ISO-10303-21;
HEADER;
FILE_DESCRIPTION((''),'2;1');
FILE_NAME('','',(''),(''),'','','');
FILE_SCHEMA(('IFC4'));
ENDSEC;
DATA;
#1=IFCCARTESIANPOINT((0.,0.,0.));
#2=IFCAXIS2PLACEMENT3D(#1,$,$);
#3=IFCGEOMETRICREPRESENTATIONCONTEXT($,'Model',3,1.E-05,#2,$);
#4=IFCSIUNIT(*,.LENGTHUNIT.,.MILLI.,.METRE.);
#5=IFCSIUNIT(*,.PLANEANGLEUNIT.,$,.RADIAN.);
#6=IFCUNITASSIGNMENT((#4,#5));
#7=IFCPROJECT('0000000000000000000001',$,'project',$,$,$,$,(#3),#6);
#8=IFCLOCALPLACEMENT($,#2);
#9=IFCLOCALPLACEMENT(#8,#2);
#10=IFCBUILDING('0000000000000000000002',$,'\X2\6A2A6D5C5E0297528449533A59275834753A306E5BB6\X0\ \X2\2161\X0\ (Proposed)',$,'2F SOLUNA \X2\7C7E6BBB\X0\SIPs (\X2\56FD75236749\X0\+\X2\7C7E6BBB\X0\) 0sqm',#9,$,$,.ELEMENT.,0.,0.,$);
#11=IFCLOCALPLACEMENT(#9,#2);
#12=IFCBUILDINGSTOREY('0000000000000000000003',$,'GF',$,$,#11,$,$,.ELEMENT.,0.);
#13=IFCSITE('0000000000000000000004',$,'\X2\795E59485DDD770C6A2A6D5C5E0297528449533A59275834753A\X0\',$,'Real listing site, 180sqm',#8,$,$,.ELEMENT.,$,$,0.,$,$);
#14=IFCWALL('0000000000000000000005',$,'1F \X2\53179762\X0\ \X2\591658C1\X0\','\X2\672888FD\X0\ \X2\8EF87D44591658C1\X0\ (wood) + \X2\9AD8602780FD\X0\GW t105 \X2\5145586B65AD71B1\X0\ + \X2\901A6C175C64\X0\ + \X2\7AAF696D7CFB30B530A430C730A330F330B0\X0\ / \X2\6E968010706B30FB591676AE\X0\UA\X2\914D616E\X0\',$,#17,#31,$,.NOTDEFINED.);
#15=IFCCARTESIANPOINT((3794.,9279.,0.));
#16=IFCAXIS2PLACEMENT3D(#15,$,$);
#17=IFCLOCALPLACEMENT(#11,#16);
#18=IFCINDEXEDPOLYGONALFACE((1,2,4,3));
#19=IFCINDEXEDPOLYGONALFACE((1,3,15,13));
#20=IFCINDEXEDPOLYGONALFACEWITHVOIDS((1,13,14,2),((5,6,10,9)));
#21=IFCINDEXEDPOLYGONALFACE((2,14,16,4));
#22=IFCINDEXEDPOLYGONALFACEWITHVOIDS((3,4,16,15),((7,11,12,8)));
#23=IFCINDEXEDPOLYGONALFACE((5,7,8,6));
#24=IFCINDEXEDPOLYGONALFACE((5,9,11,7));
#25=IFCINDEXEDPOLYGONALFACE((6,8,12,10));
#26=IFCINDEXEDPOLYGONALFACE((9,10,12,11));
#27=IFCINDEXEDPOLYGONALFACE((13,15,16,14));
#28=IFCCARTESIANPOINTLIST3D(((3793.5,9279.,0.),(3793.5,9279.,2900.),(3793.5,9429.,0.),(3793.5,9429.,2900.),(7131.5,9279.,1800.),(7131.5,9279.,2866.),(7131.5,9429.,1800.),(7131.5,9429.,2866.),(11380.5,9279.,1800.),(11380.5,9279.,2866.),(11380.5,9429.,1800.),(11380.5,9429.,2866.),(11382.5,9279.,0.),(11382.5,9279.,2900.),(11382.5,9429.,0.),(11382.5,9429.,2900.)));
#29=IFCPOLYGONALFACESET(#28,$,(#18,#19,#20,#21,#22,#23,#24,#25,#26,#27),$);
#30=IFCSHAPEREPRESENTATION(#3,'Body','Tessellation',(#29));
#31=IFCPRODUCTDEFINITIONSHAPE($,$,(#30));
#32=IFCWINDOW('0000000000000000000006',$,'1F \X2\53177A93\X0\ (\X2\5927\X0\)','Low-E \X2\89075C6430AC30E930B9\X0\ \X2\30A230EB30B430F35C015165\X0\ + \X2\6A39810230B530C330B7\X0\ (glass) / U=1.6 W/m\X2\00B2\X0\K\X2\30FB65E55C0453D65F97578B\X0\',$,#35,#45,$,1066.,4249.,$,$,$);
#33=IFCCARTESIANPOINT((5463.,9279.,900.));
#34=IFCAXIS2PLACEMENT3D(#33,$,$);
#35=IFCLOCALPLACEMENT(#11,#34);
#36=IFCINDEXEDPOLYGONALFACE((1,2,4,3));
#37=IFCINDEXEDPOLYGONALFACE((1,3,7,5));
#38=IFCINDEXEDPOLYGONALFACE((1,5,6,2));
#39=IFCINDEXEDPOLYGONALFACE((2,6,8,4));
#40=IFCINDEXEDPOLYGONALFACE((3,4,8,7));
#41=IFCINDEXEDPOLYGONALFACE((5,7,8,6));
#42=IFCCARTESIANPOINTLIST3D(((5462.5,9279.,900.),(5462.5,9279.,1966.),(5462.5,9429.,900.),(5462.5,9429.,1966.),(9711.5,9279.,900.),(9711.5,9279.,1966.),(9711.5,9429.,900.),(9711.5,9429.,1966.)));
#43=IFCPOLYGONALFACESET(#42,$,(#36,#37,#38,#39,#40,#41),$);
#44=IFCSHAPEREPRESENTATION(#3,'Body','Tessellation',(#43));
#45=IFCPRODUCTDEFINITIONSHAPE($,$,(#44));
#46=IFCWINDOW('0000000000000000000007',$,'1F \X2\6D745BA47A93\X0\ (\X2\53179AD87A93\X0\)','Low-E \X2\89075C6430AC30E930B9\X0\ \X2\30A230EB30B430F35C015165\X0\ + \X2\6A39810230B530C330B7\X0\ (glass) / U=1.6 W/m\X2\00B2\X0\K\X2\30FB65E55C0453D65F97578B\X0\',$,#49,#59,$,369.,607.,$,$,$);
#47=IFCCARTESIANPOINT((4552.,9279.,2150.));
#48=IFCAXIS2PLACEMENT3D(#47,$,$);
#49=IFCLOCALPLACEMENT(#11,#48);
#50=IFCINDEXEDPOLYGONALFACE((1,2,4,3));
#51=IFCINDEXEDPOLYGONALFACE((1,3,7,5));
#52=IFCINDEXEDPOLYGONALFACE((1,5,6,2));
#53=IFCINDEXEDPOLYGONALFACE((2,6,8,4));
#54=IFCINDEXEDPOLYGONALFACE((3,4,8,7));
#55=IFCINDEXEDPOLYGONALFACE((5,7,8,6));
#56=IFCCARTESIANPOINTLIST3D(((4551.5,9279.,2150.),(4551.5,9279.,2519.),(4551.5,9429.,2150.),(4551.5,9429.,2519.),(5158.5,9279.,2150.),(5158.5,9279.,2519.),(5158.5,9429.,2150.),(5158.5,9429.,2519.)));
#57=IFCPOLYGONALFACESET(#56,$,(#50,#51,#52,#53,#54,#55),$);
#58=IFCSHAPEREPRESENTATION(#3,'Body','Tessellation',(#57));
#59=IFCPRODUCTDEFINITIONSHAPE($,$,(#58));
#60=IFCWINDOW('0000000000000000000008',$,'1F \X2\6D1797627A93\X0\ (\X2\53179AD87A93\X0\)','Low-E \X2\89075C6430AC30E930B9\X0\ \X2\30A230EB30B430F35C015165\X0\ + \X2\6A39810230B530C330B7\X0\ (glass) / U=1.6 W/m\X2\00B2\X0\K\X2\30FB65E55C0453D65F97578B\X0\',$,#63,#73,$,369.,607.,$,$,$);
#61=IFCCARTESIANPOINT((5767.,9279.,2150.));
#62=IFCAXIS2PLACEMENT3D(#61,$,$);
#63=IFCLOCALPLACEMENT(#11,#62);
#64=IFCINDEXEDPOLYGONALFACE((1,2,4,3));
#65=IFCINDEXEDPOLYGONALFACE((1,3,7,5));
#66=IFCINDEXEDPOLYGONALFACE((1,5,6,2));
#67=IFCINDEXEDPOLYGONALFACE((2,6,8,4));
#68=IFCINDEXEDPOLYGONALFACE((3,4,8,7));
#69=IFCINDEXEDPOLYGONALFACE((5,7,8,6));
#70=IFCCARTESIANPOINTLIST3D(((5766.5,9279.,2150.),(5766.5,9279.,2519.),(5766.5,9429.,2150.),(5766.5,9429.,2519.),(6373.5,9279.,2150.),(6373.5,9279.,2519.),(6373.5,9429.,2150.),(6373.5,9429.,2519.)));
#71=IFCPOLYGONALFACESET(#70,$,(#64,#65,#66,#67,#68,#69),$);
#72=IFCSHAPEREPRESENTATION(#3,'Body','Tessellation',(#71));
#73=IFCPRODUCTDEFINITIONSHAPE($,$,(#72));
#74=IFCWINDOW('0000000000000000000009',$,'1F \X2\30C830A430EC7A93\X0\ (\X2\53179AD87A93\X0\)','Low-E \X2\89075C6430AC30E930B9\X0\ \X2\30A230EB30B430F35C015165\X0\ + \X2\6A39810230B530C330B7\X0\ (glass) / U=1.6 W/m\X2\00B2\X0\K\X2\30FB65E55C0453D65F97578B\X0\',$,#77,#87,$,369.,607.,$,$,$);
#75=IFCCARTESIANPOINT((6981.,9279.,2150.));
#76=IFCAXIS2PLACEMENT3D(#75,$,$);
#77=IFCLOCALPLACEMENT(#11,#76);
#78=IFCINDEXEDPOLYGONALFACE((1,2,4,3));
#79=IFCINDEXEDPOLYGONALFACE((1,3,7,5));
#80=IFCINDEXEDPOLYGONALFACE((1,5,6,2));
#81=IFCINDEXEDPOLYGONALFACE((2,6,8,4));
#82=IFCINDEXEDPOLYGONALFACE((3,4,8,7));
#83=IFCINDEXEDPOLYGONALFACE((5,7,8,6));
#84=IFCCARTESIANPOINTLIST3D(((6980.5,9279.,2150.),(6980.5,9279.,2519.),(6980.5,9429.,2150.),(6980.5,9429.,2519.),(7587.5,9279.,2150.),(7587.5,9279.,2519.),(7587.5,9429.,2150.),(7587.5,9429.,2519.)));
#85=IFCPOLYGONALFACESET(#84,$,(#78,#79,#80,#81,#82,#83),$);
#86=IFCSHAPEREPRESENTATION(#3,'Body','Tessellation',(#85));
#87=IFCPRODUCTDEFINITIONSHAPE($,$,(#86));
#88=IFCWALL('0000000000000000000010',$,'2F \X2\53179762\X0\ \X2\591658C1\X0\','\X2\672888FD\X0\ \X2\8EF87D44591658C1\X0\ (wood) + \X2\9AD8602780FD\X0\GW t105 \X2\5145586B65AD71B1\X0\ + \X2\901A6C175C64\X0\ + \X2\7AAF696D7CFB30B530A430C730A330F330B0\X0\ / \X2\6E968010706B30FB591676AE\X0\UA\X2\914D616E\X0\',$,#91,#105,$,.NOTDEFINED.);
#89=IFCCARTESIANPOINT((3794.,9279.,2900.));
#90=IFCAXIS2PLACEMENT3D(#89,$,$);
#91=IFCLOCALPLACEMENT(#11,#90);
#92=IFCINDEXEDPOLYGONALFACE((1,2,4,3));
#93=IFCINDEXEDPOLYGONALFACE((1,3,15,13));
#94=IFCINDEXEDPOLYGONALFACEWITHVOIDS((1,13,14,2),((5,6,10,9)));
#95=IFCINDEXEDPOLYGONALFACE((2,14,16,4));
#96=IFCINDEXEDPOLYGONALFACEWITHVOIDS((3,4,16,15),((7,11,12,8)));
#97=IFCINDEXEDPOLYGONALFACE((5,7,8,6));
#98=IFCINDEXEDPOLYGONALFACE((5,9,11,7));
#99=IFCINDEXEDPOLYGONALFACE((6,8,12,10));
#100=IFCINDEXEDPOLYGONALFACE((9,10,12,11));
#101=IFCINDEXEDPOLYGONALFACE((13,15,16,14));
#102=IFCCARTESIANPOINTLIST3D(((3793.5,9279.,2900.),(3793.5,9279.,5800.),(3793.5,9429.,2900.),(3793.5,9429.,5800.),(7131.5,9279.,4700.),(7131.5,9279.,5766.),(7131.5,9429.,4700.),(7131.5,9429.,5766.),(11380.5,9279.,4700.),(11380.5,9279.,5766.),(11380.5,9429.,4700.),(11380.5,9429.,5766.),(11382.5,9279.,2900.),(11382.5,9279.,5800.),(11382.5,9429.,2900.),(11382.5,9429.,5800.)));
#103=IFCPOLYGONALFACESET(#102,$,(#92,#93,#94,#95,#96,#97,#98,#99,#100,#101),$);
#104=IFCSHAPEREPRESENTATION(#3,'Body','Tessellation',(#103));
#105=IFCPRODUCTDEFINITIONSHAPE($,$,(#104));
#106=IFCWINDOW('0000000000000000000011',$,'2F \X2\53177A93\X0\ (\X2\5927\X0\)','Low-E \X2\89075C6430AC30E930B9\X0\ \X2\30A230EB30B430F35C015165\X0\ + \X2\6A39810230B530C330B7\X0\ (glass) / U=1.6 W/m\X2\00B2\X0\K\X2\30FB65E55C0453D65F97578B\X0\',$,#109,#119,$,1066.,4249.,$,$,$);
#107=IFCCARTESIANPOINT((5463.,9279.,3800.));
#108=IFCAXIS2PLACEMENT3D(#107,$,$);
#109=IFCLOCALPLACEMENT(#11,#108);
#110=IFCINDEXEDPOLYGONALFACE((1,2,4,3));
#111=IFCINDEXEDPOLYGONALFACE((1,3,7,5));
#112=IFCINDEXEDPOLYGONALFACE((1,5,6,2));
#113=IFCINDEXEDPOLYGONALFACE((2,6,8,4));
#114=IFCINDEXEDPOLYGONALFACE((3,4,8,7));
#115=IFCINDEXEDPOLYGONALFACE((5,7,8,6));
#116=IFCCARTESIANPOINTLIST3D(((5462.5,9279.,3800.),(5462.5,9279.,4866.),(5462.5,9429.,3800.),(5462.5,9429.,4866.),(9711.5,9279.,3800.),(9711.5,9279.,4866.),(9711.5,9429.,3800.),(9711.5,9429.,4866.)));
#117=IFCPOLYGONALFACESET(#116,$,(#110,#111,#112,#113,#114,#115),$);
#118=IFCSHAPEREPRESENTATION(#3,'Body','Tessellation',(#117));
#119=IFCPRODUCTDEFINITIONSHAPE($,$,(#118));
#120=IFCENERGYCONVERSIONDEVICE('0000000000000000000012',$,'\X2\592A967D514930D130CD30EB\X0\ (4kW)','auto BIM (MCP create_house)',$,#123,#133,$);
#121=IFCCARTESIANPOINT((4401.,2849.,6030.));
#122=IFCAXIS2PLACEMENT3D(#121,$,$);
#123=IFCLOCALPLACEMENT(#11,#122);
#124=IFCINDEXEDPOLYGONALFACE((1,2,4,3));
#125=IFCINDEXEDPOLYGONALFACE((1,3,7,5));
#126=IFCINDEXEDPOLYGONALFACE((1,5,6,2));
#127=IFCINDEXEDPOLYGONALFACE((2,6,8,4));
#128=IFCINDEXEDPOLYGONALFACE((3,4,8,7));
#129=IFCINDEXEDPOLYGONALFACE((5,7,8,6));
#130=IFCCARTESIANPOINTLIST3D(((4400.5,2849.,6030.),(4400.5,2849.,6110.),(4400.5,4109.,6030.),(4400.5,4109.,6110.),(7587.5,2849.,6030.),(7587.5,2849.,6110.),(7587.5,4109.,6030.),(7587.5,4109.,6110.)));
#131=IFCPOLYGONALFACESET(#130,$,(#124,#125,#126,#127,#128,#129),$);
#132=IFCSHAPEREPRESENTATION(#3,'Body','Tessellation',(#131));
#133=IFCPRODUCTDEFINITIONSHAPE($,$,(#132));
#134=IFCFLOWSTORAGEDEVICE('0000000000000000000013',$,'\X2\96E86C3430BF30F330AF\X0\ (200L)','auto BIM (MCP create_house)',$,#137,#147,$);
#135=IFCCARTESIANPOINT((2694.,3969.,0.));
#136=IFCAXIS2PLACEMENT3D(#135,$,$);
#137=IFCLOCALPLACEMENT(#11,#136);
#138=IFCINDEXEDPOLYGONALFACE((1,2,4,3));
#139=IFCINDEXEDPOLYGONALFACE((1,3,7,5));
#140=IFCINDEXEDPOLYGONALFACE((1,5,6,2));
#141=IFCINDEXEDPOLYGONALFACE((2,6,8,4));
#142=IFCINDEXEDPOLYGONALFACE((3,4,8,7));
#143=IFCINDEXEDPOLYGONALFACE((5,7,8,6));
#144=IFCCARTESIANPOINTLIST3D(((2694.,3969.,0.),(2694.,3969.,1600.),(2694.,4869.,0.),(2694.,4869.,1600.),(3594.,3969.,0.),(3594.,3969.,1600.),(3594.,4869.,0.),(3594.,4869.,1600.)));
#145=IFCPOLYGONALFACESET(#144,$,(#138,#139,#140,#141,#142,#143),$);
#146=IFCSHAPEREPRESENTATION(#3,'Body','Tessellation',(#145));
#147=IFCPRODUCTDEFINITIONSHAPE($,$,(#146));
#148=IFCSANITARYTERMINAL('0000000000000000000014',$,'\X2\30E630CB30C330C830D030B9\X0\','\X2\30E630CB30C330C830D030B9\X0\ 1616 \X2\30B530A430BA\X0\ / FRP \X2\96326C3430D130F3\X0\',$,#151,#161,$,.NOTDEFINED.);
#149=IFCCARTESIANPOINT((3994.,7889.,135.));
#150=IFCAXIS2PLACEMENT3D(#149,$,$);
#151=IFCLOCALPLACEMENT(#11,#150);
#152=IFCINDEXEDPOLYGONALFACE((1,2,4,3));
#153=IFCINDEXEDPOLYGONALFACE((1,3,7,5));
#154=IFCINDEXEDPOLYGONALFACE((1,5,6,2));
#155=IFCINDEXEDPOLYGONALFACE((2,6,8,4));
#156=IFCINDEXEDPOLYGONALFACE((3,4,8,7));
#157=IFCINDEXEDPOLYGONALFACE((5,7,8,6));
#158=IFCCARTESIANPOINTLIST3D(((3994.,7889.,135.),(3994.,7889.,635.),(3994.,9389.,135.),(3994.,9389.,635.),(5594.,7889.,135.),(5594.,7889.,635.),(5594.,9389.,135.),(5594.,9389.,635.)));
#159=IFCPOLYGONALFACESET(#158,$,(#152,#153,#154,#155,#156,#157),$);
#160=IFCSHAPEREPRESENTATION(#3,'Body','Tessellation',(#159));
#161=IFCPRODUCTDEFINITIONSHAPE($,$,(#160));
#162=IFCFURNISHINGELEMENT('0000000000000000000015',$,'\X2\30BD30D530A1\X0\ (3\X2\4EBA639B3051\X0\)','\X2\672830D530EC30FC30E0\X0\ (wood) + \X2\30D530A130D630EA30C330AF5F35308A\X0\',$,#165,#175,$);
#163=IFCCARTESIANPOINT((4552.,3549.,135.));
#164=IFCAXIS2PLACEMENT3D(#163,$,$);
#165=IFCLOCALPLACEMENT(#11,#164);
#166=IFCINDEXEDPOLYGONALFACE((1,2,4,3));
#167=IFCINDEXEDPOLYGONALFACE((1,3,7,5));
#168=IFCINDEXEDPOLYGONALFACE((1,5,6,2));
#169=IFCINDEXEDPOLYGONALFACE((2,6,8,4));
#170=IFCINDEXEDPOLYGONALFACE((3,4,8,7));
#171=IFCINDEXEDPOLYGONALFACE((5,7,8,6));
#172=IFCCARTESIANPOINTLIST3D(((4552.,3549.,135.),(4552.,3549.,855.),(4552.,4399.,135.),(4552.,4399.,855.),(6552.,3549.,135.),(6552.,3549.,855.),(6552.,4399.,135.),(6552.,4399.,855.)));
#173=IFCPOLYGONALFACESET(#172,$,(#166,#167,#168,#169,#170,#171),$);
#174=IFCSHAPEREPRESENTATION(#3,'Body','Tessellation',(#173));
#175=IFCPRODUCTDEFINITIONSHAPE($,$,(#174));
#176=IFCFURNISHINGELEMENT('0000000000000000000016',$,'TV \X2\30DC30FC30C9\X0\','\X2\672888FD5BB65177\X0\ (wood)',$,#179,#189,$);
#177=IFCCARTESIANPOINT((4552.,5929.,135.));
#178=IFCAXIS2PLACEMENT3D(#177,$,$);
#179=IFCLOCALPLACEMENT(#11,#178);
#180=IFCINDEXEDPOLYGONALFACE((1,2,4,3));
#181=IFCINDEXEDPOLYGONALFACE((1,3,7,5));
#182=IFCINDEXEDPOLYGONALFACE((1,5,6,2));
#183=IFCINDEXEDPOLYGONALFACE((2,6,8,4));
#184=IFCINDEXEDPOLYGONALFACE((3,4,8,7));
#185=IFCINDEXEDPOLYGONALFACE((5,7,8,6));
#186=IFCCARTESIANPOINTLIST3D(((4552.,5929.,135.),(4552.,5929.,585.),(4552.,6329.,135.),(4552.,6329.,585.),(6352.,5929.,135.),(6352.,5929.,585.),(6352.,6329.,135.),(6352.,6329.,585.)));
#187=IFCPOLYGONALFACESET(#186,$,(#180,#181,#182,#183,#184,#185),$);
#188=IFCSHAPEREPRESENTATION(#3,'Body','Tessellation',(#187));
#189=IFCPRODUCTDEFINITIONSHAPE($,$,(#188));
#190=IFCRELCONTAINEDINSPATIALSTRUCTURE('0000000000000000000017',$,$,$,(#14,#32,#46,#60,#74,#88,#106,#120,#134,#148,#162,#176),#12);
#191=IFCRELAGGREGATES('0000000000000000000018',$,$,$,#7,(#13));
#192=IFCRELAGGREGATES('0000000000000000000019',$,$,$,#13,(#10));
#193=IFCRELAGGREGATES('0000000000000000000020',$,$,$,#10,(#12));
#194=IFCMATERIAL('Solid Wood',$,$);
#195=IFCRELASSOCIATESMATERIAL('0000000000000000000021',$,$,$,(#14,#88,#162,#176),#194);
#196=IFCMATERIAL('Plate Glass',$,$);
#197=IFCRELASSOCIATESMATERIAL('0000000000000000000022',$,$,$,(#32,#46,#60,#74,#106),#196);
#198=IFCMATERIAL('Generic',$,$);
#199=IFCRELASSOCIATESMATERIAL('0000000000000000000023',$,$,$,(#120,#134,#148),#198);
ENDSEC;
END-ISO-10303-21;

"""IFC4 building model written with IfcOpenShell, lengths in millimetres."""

from ifc_helpers import new_model, si_unit, frame, frame_2d, origin, place, context, project, spatial, rectangle, extrude, material, element, fill, save


model = new_model("IFC4")

# Units and contexts
model_context = context("Model", 3, precision=1e-05, world=origin())
ifc_project = project(units=[si_unit("LENGTHUNIT", "METRE", prefix="MILLI"), si_unit("PLANEANGLEUNIT", "RADIAN")], contexts=[model_context])

# Site, building, storey
site_placement = place(None, origin())
site = spatial("IfcSite", under=ifc_project, at=site_placement, Name="神奈川県横浜市青葉区大場町", ObjectType="Real listing site, 180sqm", CompositionType="ELEMENT", RefElevation=0.0)
building_placement = place(site_placement, origin())
building = spatial("IfcBuilding", under=site, at=building_placement, Name="横浜市青葉区大場町の家 Ⅱ (Proposed)", ObjectType="2F SOLUNA 籾殻SIPs (国産杉+籾殻) 0sqm", CompositionType="ELEMENT", ElevationOfRefHeight=0.0, ElevationOfTerrain=0.0)
storey_placement = place(building_placement, origin())
storey = spatial("IfcBuildingStorey", under=building, at=storey_placement, Name="GF", CompositionType="ELEMENT", Elevation=0.0)

# Wall, openings, windows
ifc_material_1 = material(Name="Solid Wood")
wall_1_placement = place(storey_placement, frame((3794.0, 9279.0, 0.0)))
wall_1 = element("IfcWall", 1, at=wall_1_placement, inside=storey, material=ifc_material_1, Name="1F 北面 外壁", Description="木製 軸組外壁 (wood) + 高性能GW t105 充填断熱 + 通気層 + 窯業系サイディング / 準耐火・外皮UA配慮", PredefinedType="NOTDEFINED", context=model_context, shape_type="SweptSolid", body=[
    extrude(rectangle(XDim=7589.0, YDim=150.0, at=frame_2d((3794.0, 75.0))), frame((3794.0, 9279.0, 0.0)), (0.0, 0.0, 1.0), 2900.0),
])
opening_1_placement = place(storey_placement, frame((5463.0, 9279.0, 900.0)))
opening_1 = element("IfcOpeningElement", 2, at=opening_1_placement, cuts=wall_1, PredefinedType="NOTDEFINED", context=model_context, shape_type="SweptSolid", body=[
    extrude(rectangle(XDim=4249.0, YDim=150.0, at=frame_2d((2124.0, 75.0))), frame((5463.0, 9279.0, 900.0)), (0.0, 0.0, 1.0), 1066.0),
])
opening_2_placement = place(storey_placement, frame((4552.0, 9279.0, 2150.0)))
opening_2 = element("IfcOpeningElement", 3, at=opening_2_placement, cuts=wall_1, PredefinedType="NOTDEFINED", context=model_context, shape_type="SweptSolid", body=[
    extrude(rectangle(XDim=607.0, YDim=150.0, at=frame_2d((303.0, 75.0))), frame((4552.0, 9279.0, 2150.0)), (0.0, 0.0, 1.0), 369.0),
])
opening_3_placement = place(storey_placement, frame((5767.0, 9279.0, 2150.0)))
opening_3 = element("IfcOpeningElement", 4, at=opening_3_placement, cuts=wall_1, PredefinedType="NOTDEFINED", context=model_context, shape_type="SweptSolid", body=[
    extrude(rectangle(XDim=607.0, YDim=150.0, at=frame_2d((303.0, 75.0))), frame((5767.0, 9279.0, 2150.0)), (0.0, 0.0, 1.0), 369.0),
])
opening_4_placement = place(storey_placement, frame((6981.0, 9279.0, 2150.0)))
opening_4 = element("IfcOpeningElement", 5, at=opening_4_placement, cuts=wall_1, PredefinedType="NOTDEFINED", context=model_context, shape_type="SweptSolid", body=[
    extrude(rectangle(XDim=607.0, YDim=150.0, at=frame_2d((303.0, 75.0))), frame((6981.0, 9279.0, 2150.0)), (0.0, 0.0, 1.0), 369.0),
])
ifc_material_2 = material(Name="Plate Glass")
window_1_placement = place(storey_placement, frame((5463.0, 9279.0, 900.0)))
window_1 = element("IfcWindow", 6, at=window_1_placement, inside=storey, material=ifc_material_2, Name="1F 北窓 (大)", Description="Low-E 複層ガラス アルゴン封入 + 樹脂サッシ (glass) / U=1.6 W/m²K・日射取得型", OverallHeight=1066.0, OverallWidth=4249.0, context=model_context, shape_type="SweptSolid", body=[
    extrude(rectangle(XDim=4249.0, YDim=150.0, at=frame_2d((2124.0, 75.0))), frame((5463.0, 9279.0, 900.0)), (0.0, 0.0, 1.0), 1066.0),
])
fill(opening_1, window_1)
window_2_placement = place(storey_placement, frame((4552.0, 9279.0, 2150.0)))
window_2 = element("IfcWindow", 7, at=window_2_placement, inside=storey, material=ifc_material_2, Name="1F 浴室窓 (北高窓)", Description="Low-E 複層ガラス アルゴン封入 + 樹脂サッシ (glass) / U=1.6 W/m²K・日射取得型", OverallHeight=369.0, OverallWidth=607.0, context=model_context, shape_type="SweptSolid", body=[
    extrude(rectangle(XDim=607.0, YDim=150.0, at=frame_2d((303.0, 75.0))), frame((4552.0, 9279.0, 2150.0)), (0.0, 0.0, 1.0), 369.0),
])
fill(opening_2, window_2)
window_3_placement = place(storey_placement, frame((5767.0, 9279.0, 2150.0)))
window_3 = element("IfcWindow", 8, at=window_3_placement, inside=storey, material=ifc_material_2, Name="1F 洗面窓 (北高窓)", Description="Low-E 複層ガラス アルゴン封入 + 樹脂サッシ (glass) / U=1.6 W/m²K・日射取得型", OverallHeight=369.0, OverallWidth=607.0, context=model_context, shape_type="SweptSolid", body=[
    extrude(rectangle(XDim=607.0, YDim=150.0, at=frame_2d((303.0, 75.0))), frame((5767.0, 9279.0, 2150.0)), (0.0, 0.0, 1.0), 369.0),
])
fill(opening_3, window_3)
window_4_placement = place(storey_placement, frame((6981.0, 9279.0, 2150.0)))
window_4 = element("IfcWindow", 9, at=window_4_placement, inside=storey, material=ifc_material_2, Name="1F トイレ窓 (北高窓)", Description="Low-E 複層ガラス アルゴン封入 + 樹脂サッシ (glass) / U=1.6 W/m²K・日射取得型", OverallHeight=369.0, OverallWidth=607.0, context=model_context, shape_type="SweptSolid", body=[
    extrude(rectangle(XDim=607.0, YDim=150.0, at=frame_2d((303.0, 75.0))), frame((6981.0, 9279.0, 2150.0)), (0.0, 0.0, 1.0), 369.0),
])
fill(opening_4, window_4)

# Wall, opening, window
wall_2_placement = place(storey_placement, frame((3794.0, 9279.0, 2900.0)))
wall_2 = element("IfcWall", 10, at=wall_2_placement, inside=storey, material=ifc_material_1, Name="2F 北面 外壁", Description="木製 軸組外壁 (wood) + 高性能GW t105 充填断熱 + 通気層 + 窯業系サイディング / 準耐火・外皮UA配慮", PredefinedType="NOTDEFINED", context=model_context, shape_type="SweptSolid", body=[
    extrude(rectangle(XDim=7589.0, YDim=150.0, at=frame_2d((3794.0, 75.0))), frame((3794.0, 9279.0, 2900.0)), (0.0, 0.0, 1.0), 2900.0),
])
opening_5_placement = place(storey_placement, frame((5463.0, 9279.0, 3800.0)))
opening_5 = element("IfcOpeningElement", 11, at=opening_5_placement, cuts=wall_2, PredefinedType="NOTDEFINED", context=model_context, shape_type="SweptSolid", body=[
    extrude(rectangle(XDim=4249.0, YDim=150.0, at=frame_2d((2124.0, 75.0))), frame((5463.0, 9279.0, 3800.0)), (0.0, 0.0, 1.0), 1066.0),
])
window_5_placement = place(storey_placement, frame((5463.0, 9279.0, 3800.0)))
window_5 = element("IfcWindow", 12, at=window_5_placement, inside=storey, material=ifc_material_2, Name="2F 北窓 (大)", Description="Low-E 複層ガラス アルゴン封入 + 樹脂サッシ (glass) / U=1.6 W/m²K・日射取得型", OverallHeight=1066.0, OverallWidth=4249.0, context=model_context, shape_type="SweptSolid", body=[
    extrude(rectangle(XDim=4249.0, YDim=150.0, at=frame_2d((2124.0, 75.0))), frame((5463.0, 9279.0, 3800.0)), (0.0, 0.0, 1.0), 1066.0),
])
fill(opening_5, window_5)

# Energy conversion device
ifc_material_3 = material(Name="Generic")
energy_conversion_device_placement = place(storey_placement, frame((4401.0, 2849.0, 6030.0)))
element("IfcEnergyConversionDevice", 13, at=energy_conversion_device_placement, inside=storey, material=ifc_material_3, Name="太陽光パネル (4kW)", Description="auto BIM (MCP create_house)", context=model_context, shape_type="SweptSolid", body=[
    extrude(rectangle(XDim=3187.0, YDim=1260.0, at=frame_2d((1593.0, 630.0))), frame((4401.0, 2849.0, 6030.0)), (0.0, 0.0, 1.0), 80.0),
])

# Flow storage device
flow_storage_device_placement = place(storey_placement, frame((2694.0, 3969.0, 0.0)))
element("IfcFlowStorageDevice", 14, at=flow_storage_device_placement, inside=storey, material=ifc_material_3, Name="雨水タンク (200L)", Description="auto BIM (MCP create_house)", context=model_context, shape_type="SweptSolid", body=[
    extrude(rectangle(XDim=900.0, YDim=900.0, at=frame_2d((450.0, 450.0))), frame((2694.0, 3969.0, 0.0)), (0.0, 0.0, 1.0), 1600.0),
])

# Sanitary terminal
sanitary_terminal_placement = place(storey_placement, frame((3994.0, 7889.0, 135.0)))
element("IfcSanitaryTerminal", 15, at=sanitary_terminal_placement, inside=storey, material=ifc_material_3, Name="ユニットバス", Description="ユニットバス 1616 サイズ / FRP 防水パン", PredefinedType="NOTDEFINED", context=model_context, shape_type="SweptSolid", body=[
    extrude(rectangle(XDim=1600.0, YDim=1500.0, at=frame_2d((800.0, 750.0))), frame((3994.0, 7889.0, 135.0)), (0.0, 0.0, 1.0), 500.0),
])

# Furnishing elements
furnishing_1_placement = place(storey_placement, frame((4552.0, 3549.0, 135.0)))
element("IfcFurnishingElement", 16, at=furnishing_1_placement, inside=storey, material=ifc_material_1, Name="ソファ (3人掛け)", Description="木フレーム (wood) + ファブリック張り", context=model_context, shape_type="SweptSolid", body=[
    extrude(rectangle(XDim=2000.0, YDim=850.0, at=frame_2d((1000.0, 425.0))), frame((4552.0, 3549.0, 135.0)), (0.0, 0.0, 1.0), 720.0),
])
furnishing_2_placement = place(storey_placement, frame((4552.0, 5929.0, 135.0)))
element("IfcFurnishingElement", 17, at=furnishing_2_placement, inside=storey, material=ifc_material_1, Name="TV ボード", Description="木製家具 (wood)", context=model_context, shape_type="SweptSolid", body=[
    extrude(rectangle(XDim=1800.0, YDim=400.0, at=frame_2d((900.0, 200.0))), frame((4552.0, 5929.0, 135.0)), (0.0, 0.0, 1.0), 450.0),
])

save(model, "model.ifc")
